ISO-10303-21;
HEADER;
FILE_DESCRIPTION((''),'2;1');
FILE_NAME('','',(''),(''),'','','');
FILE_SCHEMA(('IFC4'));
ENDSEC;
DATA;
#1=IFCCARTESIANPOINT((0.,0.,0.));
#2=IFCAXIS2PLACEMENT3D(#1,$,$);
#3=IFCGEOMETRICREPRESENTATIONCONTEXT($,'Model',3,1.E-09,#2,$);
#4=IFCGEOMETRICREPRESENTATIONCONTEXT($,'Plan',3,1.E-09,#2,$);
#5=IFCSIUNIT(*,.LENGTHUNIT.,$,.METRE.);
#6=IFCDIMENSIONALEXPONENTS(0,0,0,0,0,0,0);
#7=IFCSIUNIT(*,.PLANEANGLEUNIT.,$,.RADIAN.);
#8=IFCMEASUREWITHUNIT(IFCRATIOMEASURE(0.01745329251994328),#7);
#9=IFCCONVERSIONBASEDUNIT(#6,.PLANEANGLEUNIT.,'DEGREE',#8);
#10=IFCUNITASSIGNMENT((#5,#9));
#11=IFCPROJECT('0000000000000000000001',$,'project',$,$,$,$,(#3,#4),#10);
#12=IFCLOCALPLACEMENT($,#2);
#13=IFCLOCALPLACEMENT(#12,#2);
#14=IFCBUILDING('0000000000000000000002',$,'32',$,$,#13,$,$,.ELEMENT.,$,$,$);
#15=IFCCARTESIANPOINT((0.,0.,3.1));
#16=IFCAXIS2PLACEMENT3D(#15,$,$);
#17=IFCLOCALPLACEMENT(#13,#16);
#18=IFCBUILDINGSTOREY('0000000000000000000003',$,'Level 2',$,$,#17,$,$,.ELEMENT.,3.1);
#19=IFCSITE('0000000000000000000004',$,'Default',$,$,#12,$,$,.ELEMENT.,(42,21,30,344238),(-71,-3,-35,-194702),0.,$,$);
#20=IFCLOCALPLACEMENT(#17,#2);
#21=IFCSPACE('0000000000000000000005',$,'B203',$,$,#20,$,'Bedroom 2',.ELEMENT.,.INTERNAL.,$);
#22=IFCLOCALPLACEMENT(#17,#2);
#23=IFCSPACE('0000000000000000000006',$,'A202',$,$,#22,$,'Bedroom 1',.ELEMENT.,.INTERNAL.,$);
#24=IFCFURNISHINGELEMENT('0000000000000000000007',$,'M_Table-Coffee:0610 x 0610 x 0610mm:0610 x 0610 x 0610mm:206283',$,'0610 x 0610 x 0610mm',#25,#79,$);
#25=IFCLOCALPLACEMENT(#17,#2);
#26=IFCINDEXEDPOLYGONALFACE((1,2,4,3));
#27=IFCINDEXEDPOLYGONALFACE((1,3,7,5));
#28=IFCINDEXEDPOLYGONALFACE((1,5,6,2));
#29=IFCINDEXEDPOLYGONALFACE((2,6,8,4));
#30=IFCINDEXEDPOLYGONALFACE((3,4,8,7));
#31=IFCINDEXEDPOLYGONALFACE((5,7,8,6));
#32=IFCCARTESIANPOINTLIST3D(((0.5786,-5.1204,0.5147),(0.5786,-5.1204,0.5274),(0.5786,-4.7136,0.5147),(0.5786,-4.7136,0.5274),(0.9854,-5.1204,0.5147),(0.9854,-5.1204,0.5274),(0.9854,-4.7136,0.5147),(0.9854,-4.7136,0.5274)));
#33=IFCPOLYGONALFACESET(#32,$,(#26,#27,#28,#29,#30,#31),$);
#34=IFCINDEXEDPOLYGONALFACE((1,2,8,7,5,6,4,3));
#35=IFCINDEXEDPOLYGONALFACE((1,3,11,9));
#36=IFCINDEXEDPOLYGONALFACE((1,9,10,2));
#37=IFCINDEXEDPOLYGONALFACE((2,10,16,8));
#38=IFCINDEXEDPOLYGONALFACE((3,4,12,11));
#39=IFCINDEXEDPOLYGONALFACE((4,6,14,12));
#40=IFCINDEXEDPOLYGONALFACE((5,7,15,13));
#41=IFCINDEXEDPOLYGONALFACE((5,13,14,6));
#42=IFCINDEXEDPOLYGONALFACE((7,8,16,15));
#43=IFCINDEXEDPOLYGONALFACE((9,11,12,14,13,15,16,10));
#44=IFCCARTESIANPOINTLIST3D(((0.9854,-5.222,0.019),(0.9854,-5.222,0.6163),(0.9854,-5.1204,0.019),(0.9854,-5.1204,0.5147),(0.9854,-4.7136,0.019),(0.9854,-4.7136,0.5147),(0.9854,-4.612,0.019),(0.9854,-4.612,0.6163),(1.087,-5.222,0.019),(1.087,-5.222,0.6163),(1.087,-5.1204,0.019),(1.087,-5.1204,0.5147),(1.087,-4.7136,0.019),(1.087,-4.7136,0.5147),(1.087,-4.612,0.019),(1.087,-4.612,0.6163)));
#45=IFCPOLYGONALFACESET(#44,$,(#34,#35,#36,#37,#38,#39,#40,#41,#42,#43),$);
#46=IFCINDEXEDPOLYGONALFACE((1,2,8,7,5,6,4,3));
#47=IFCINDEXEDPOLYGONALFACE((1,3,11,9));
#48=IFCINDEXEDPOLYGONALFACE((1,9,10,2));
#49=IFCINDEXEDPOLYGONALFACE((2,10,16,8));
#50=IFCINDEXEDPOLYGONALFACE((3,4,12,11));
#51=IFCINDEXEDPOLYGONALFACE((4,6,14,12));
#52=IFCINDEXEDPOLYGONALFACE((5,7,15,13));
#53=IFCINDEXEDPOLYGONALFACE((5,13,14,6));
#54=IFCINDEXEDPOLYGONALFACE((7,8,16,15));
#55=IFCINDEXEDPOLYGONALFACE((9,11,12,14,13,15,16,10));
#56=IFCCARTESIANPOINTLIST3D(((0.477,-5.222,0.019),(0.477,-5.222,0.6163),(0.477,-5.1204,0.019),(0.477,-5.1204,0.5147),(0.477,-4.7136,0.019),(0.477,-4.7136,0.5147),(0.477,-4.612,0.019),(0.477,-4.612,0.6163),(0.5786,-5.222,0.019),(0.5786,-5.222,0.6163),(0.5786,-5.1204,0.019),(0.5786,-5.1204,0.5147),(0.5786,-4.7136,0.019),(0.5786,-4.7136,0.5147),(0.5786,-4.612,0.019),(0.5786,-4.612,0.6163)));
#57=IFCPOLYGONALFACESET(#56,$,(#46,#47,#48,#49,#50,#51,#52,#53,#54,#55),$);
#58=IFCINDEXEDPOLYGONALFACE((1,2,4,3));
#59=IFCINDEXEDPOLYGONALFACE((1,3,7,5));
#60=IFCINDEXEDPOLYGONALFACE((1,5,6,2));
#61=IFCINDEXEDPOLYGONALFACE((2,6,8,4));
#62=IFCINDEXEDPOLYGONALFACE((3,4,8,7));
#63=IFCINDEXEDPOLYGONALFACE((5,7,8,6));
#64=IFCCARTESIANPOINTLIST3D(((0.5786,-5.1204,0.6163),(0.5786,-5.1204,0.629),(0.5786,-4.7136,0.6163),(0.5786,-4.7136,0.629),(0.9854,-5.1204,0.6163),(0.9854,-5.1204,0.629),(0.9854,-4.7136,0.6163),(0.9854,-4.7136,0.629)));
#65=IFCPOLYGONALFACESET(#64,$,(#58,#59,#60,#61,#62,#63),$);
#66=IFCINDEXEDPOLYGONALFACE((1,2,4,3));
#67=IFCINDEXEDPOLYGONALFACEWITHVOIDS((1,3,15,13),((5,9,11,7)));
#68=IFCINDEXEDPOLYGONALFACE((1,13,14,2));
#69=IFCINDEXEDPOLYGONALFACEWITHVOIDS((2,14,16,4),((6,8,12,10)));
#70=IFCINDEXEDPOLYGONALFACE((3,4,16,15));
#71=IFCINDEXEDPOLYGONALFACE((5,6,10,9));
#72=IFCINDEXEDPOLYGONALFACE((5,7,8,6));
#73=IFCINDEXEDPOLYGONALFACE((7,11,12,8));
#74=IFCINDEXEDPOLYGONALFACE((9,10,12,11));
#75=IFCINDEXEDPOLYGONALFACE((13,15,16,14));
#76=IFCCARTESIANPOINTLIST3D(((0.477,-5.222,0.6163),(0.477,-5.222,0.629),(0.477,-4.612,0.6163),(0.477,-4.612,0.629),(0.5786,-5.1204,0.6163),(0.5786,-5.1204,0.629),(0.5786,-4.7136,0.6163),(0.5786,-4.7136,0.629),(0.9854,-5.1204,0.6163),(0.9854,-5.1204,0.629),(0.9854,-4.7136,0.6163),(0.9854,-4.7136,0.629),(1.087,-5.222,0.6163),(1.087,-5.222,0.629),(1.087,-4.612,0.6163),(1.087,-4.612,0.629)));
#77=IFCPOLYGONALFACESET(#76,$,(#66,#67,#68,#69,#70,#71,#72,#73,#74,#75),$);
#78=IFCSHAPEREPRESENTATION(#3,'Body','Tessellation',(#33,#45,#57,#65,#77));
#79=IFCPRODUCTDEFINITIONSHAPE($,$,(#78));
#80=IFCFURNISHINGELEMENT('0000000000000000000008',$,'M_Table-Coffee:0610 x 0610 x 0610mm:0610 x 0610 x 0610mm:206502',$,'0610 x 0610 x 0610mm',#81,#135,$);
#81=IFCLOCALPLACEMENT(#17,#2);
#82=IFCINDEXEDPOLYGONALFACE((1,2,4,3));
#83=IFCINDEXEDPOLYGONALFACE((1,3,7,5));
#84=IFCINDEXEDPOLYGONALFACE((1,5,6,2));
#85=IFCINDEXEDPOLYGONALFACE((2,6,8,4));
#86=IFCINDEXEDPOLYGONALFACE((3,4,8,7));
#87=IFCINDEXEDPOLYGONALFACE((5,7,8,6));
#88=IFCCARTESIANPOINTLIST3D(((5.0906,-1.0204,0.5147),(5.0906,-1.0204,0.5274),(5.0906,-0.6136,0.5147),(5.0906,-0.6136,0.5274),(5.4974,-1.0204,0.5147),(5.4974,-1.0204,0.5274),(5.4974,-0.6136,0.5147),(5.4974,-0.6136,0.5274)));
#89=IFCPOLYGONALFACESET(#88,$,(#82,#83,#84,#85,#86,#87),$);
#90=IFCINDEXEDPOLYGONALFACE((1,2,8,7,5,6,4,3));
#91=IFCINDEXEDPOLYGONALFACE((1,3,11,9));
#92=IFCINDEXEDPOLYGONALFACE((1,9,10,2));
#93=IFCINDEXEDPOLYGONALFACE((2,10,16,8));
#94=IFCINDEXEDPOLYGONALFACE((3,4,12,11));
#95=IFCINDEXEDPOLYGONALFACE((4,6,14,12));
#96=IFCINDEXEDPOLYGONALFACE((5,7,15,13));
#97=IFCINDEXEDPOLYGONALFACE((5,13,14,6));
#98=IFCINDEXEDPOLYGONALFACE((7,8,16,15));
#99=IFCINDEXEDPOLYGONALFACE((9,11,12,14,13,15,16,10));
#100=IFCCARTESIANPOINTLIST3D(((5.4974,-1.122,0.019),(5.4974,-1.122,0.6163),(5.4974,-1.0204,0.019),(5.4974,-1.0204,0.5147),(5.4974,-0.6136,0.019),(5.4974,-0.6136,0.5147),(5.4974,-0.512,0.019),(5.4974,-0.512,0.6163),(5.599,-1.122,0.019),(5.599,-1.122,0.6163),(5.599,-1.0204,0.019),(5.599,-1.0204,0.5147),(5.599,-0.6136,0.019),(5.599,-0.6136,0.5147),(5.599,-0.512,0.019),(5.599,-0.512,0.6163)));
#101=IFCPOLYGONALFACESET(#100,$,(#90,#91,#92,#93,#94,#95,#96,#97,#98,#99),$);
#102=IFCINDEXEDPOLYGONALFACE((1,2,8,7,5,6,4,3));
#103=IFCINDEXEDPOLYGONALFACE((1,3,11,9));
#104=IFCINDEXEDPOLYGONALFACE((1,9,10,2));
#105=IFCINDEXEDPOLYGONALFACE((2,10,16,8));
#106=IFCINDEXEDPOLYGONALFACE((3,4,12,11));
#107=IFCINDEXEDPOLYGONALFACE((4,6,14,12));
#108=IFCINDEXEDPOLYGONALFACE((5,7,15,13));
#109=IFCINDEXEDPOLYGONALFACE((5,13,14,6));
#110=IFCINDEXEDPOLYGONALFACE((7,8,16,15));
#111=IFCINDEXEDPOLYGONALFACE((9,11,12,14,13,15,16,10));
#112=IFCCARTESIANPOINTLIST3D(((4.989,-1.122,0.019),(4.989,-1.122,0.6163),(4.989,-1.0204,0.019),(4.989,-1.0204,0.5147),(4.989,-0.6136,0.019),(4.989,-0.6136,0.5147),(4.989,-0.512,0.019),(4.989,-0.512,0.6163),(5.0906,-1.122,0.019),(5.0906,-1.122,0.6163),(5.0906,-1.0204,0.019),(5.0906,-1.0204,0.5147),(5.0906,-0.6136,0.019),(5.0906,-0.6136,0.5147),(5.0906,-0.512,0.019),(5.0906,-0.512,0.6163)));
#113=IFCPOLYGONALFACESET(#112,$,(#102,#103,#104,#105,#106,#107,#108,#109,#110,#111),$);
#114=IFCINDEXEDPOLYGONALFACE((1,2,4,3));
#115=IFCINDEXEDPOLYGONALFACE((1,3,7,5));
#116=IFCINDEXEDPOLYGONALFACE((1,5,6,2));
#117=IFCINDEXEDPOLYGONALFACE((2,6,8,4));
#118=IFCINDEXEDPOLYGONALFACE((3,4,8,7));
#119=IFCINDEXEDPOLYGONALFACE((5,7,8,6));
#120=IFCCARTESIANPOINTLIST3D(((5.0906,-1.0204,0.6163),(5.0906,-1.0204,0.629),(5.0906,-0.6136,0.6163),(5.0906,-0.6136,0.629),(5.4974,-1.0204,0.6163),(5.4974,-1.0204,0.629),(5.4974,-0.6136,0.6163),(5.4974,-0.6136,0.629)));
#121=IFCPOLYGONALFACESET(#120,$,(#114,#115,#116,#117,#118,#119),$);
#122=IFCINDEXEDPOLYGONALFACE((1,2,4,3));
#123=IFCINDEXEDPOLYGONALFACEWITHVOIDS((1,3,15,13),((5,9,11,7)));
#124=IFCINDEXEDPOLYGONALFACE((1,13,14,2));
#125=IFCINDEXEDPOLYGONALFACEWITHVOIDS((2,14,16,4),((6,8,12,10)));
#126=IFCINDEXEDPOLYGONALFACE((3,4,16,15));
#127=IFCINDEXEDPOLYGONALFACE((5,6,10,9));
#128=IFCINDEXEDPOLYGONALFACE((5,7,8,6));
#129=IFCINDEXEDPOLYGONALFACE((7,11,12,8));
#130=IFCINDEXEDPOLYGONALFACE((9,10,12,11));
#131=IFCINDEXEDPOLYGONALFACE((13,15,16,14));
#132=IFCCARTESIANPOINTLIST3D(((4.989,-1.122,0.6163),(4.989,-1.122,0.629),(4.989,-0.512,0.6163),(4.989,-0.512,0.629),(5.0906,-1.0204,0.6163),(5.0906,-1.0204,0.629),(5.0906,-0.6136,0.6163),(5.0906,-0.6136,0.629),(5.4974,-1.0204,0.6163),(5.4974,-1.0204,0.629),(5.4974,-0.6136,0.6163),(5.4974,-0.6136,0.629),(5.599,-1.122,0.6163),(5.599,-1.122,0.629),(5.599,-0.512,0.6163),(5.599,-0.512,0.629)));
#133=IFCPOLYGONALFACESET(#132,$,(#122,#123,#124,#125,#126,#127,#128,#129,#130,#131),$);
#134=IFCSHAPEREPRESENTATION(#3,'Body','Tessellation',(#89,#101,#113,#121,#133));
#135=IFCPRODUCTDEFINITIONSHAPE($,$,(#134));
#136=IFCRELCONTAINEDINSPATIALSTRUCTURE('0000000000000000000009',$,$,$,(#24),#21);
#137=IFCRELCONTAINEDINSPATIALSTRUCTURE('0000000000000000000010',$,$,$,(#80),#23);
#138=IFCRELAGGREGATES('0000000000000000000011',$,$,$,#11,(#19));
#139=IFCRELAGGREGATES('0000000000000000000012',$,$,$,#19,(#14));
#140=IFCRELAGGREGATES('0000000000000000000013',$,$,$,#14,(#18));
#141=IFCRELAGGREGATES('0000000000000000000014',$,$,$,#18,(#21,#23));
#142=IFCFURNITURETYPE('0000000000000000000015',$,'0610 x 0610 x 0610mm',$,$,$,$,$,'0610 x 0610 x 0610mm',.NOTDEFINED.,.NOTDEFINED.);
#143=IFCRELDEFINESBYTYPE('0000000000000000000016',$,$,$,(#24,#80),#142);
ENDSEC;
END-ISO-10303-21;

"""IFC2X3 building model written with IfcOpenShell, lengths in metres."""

from ifc_helpers import new_model, entity, si_unit, converted_unit, frame, origin, origin_2d_with_axis, place, context, project, spatial, polyline, rectangle, outline, extrude, source, transform, mapped, type_object, type_shapes, element, save


model = new_model("IFC2X3")

# Units and contexts
model_context = context("Model", 3, precision=1e-09, world=origin())
plan_context = context("Plan", 3, precision=1e-09, world=origin())
ifc_project = project(units=[si_unit("LENGTHUNIT", "METRE"), converted_unit("PLANEANGLEUNIT", "DEGREE", entity("IfcRatioMeasure", 0.01745329251994328), si_unit("PLANEANGLEUNIT", "RADIAN"), dimensions=[0, 0, 0, 0, 0, 0, 0])], contexts=[model_context, plan_context])

# Site, building, storey
site_placement = place(None, origin())
site = spatial("IfcSite", under=ifc_project, at=site_placement, Name="Default", CompositionType="ELEMENT", RefLatitude=(42, 21, 30, 344238), RefLongitude=(-71, -3, -35, -194702), RefElevation=0.0)
building_placement = place(site_placement, origin())
building = spatial("IfcBuilding", under=site, at=building_placement, Name="32", CompositionType="ELEMENT")
storey_placement = place(building_placement, frame((0.0, 0.0, 3.1)))
storey = spatial("IfcBuildingStorey", under=building, at=storey_placement, Name="Level 2", CompositionType="ELEMENT", Elevation=3.1)

# Shared definitions
space_1_placement = place(storey_placement, origin())
space_1 = spatial("IfcSpace", under=storey, at=space_1_placement, Name="B203", LongName="Bedroom 2", CompositionType="ELEMENT", InteriorOrExteriorSpace="INTERNAL")

# Furnishing element
furniture_type = type_object("IfcFurnitureType", Name="0610 x 0610 x 0610mm", ElementType="0610 x 0610 x 0610mm", AssemblyPlace="NOTDEFINED")
shared_shape_1 = source(origin(), model_context, "Body", "SweptSolid", [
    extrude(rectangle(XDim=0.4068, YDim=0.4068, at=origin_2d_with_axis()), frame((0.0183, 0.0952, 0.4957), z_axis=(0.0, 0.0, 1.0), x_axis=(-1.0, 0.0, 0.0)), (0.0, 0.0, 1.0), 0.0127),
    extrude(outline(polyline([(-0.2732, -0.305), (0.324, -0.305), (0.324, 0.305), (-0.2732, 0.305), (-0.2732, 0.2034), (0.2225, 0.2034), (0.2225, -0.2034), (-0.2732, -0.2034), (-0.2732, -0.305)])), frame((0.2217, 0.0952, 0.2732), z_axis=(1.0, 0.0, 0.0), x_axis=(0.0, 0.0, 1.0)), (0.0, 0.0, 1.0), 0.1016),
    extrude(outline(polyline([(-0.305, -0.3241), (0.305, -0.3241), (0.305, 0.2733), (0.2034, 0.2733), (0.2034, -0.2224), (-0.2034, -0.2224), (-0.2034, 0.2733), (-0.305, 0.2733), (-0.305, -0.3241)])), frame((-0.2867, 0.0952, 0.2733), z_axis=(1.0, 0.0, 0.0), x_axis=(0.0, -1.0, 0.0)), (0.0, 0.0, 1.0), 0.1016),
    extrude(rectangle(XDim=0.4068, YDim=0.4068, at=origin_2d_with_axis()), frame((0.0183, 0.0952, 0.5973), z_axis=(0.0, 0.0, 1.0), x_axis=(-1.0, 0.0, 0.0)), (0.0, 0.0, 1.0), 0.0127),
    extrude(outline(polyline([(-0.305, -0.305), (0.305, -0.305), (0.305, 0.305), (-0.305, 0.305), (-0.305, -0.305)]), holes=[polyline([(-0.2034, -0.2034), (-0.2034, 0.2034), (0.2034, 0.2034), (0.2034, -0.2034), (-0.2034, -0.2034)])]), frame((0.0183, 0.0952, 0.5973), z_axis=(0.0, 0.0, 1.0), x_axis=(-1.0, 0.0, 0.0)), (0.0, 0.0, 1.0), 0.0127),
])
type_shapes(furniture_type, [shared_shape_1])
furnishing_1_placement = place(space_1_placement, frame((0.7637, -5.0122, 0.019)))
element("IfcFurnishingElement", 1, at=furnishing_1_placement, inside=space_1, type_object=furniture_type, Name="M_Table-Coffee:0610 x 0610 x 0610mm:0610 x 0610 x 0610mm:206283", ObjectType="0610 x 0610 x 0610mm", context=model_context, shape_type="MappedRepresentation", body=[
    mapped(shared_shape_1, transform((0.0, 0.0, 0.0), scale=1.0)),
])

# Shared definitions
space_2_placement = place(storey_placement, origin())
space_2 = spatial("IfcSpace", under=storey, at=space_2_placement, Name="A202", LongName="Bedroom 1", CompositionType="ELEMENT", InteriorOrExteriorSpace="INTERNAL")

# Furnishing element
furnishing_2_placement = place(space_2_placement, frame((5.2757, -0.9122, 0.019)))
element("IfcFurnishingElement", 2, at=furnishing_2_placement, inside=space_2, type_object=furniture_type, Name="M_Table-Coffee:0610 x 0610 x 0610mm:0610 x 0610 x 0610mm:206502", ObjectType="0610 x 0610 x 0610mm", context=model_context, shape_type="MappedRepresentation", body=[
    mapped(shared_shape_1, transform((0.0, 0.0, 0.0), scale=1.0)),
])

save(model, "model.ifc")
